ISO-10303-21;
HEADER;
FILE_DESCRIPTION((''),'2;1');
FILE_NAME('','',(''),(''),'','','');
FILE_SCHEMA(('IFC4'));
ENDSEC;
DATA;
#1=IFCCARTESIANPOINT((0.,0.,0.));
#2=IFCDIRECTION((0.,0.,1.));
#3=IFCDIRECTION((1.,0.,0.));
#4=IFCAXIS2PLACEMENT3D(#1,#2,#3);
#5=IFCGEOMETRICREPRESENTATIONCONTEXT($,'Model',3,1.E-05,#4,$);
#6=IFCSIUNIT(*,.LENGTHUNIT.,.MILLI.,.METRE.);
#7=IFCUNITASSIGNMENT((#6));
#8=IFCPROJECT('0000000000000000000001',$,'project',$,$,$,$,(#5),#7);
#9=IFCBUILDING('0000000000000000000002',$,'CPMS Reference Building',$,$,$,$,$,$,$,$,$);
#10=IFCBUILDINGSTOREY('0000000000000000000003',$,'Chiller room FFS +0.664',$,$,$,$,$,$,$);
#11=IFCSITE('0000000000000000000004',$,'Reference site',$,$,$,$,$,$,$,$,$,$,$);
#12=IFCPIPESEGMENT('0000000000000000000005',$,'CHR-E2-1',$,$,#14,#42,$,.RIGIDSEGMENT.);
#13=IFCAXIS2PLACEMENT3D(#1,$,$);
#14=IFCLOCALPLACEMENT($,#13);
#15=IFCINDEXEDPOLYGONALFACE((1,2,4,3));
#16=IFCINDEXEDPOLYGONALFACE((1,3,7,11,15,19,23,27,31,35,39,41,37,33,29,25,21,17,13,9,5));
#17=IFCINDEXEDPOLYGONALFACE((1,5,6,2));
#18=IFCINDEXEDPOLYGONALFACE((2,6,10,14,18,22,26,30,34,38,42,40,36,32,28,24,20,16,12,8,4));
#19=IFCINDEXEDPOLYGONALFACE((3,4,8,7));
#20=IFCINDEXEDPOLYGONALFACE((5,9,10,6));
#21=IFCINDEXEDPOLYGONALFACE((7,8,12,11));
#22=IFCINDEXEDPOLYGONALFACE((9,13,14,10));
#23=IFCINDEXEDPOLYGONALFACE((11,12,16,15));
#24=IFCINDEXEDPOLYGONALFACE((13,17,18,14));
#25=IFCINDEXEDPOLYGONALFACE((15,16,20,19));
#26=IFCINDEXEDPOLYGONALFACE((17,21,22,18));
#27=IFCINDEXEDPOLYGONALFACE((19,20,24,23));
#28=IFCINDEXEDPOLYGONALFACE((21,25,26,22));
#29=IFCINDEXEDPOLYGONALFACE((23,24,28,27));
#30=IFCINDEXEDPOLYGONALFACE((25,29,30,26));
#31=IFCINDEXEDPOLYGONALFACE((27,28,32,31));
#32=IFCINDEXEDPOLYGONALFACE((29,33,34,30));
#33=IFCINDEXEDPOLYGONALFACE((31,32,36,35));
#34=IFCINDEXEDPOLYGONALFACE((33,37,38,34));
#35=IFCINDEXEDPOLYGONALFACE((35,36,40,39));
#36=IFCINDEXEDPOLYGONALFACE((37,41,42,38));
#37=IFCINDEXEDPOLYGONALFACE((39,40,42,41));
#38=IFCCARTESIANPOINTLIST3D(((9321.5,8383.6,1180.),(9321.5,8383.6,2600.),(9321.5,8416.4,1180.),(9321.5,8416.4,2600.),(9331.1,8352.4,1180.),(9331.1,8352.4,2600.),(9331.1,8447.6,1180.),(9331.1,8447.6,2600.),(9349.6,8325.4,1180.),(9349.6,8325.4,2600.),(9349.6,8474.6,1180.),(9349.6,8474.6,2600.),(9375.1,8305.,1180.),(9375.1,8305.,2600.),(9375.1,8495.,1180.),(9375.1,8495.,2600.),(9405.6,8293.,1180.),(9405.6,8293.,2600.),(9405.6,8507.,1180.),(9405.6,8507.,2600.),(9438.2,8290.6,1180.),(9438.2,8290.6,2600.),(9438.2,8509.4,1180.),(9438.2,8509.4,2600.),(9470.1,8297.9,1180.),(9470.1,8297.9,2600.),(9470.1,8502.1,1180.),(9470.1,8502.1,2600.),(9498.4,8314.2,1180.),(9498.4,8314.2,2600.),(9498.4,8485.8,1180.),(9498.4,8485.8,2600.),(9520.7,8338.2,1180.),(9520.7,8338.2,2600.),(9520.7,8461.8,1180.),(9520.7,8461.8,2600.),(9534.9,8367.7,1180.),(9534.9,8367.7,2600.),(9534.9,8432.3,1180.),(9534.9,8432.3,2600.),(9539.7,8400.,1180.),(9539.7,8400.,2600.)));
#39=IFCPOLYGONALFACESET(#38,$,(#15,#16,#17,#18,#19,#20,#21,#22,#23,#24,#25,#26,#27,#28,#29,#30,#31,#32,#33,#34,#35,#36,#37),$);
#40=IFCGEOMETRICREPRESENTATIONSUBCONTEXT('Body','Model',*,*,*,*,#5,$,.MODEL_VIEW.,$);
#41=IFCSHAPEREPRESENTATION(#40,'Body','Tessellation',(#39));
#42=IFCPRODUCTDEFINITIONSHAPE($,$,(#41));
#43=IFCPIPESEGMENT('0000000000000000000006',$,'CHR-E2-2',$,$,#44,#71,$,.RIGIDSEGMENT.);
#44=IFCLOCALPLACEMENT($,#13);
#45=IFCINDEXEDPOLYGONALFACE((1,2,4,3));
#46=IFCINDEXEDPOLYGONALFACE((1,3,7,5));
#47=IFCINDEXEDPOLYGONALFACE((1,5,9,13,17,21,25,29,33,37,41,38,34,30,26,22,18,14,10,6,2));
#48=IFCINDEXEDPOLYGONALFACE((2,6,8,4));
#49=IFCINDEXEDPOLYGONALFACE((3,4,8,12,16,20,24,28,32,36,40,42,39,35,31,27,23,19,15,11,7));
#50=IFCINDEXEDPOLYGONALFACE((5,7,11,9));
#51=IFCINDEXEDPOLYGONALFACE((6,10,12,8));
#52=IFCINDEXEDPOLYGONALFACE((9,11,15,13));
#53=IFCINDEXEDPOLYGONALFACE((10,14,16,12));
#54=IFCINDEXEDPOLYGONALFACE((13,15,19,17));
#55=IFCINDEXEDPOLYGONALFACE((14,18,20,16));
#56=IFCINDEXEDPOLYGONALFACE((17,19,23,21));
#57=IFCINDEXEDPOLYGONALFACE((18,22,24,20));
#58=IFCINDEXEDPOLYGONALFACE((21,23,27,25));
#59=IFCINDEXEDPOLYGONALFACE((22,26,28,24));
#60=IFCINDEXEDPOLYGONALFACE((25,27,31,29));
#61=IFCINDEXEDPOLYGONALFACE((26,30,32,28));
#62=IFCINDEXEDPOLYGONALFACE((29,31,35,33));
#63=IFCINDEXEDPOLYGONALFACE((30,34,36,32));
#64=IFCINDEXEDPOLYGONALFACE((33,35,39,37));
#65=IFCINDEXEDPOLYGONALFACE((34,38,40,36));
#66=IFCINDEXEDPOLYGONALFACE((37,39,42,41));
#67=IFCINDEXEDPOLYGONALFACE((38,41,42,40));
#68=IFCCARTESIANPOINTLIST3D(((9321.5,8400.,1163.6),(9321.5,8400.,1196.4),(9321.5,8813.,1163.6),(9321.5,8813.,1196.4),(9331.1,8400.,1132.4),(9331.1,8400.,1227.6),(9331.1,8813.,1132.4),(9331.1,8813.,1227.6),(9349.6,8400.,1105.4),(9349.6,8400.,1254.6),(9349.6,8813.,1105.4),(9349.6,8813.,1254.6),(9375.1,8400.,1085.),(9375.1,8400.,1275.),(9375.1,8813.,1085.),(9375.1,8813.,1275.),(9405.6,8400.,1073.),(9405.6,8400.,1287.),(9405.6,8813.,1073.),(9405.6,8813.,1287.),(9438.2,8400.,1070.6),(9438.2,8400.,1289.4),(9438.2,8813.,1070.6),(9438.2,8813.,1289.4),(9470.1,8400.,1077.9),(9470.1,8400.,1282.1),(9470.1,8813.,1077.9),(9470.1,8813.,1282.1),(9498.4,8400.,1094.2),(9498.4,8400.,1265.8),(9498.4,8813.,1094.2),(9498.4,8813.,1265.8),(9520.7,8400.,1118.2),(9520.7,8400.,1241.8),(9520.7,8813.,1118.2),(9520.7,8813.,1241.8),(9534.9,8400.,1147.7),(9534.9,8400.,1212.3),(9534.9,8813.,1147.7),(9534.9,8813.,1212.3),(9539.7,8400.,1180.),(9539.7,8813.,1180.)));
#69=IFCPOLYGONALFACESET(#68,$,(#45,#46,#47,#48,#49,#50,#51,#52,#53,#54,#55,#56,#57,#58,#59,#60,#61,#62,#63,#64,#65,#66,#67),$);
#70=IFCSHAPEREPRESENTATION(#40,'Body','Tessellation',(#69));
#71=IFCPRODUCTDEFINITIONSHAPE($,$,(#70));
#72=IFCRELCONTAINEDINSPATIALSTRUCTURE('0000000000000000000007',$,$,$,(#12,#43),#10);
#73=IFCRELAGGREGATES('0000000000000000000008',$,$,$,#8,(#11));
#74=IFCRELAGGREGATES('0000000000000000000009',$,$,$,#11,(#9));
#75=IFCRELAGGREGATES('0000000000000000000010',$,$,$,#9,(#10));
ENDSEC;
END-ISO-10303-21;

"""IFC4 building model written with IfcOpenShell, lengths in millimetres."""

from ifc_helpers import new_model, si_unit, frame, origin_with_axes, origin_2d, place, context, subcontext, project, spatial, circle_curve, outline, extrude, element, save


model = new_model("IFC4")

# Units and contexts
model_context = context("Model", 3, precision=1e-05, world=origin_with_axes())
body_context = subcontext(model_context, "Body", "Model", "MODEL_VIEW")
ifc_project = project(units=[si_unit("LENGTHUNIT", "METRE", prefix="MILLI")], contexts=[model_context])

# Site, building, storey
site = spatial("IfcSite", under=ifc_project, Name="Reference site")
building = spatial("IfcBuilding", under=site, Name="CPMS Reference Building")
storey = spatial("IfcBuildingStorey", under=building, Name="Chiller room FFS +0.664")

# Pipe segments
pipe_segment_1_placement = place(None, origin_with_axes())
element("IfcPipeSegment", 1, at=pipe_segment_1_placement, inside=storey, Name="CHR-E2-1", PredefinedType="RIGIDSEGMENT", context=body_context, shape_type="SweptSolid", body=[
    extrude(outline(circle_curve(origin_2d(), 109.7)), frame((9430.0, 8400.0, 2600.0), z_axis=(0.0, 0.0, -1.0), x_axis=(1.0, 0.0, 0.0)), (0.0, 0.0, 1.0), 1420.0),
])
pipe_segment_2_placement = place(None, origin_with_axes())
element("IfcPipeSegment", 2, at=pipe_segment_2_placement, inside=storey, Name="CHR-E2-2", PredefinedType="RIGIDSEGMENT", context=body_context, shape_type="SweptSolid", body=[
    extrude(outline(circle_curve(origin_2d(), 109.7)), frame((9430.0, 8400.0, 1180.0), z_axis=(0.0, 1.0, 0.0), x_axis=(1.0, 0.0, 0.0)), (0.0, 0.0, 1.0), 413.0),
])

save(model, "model.ifc")
